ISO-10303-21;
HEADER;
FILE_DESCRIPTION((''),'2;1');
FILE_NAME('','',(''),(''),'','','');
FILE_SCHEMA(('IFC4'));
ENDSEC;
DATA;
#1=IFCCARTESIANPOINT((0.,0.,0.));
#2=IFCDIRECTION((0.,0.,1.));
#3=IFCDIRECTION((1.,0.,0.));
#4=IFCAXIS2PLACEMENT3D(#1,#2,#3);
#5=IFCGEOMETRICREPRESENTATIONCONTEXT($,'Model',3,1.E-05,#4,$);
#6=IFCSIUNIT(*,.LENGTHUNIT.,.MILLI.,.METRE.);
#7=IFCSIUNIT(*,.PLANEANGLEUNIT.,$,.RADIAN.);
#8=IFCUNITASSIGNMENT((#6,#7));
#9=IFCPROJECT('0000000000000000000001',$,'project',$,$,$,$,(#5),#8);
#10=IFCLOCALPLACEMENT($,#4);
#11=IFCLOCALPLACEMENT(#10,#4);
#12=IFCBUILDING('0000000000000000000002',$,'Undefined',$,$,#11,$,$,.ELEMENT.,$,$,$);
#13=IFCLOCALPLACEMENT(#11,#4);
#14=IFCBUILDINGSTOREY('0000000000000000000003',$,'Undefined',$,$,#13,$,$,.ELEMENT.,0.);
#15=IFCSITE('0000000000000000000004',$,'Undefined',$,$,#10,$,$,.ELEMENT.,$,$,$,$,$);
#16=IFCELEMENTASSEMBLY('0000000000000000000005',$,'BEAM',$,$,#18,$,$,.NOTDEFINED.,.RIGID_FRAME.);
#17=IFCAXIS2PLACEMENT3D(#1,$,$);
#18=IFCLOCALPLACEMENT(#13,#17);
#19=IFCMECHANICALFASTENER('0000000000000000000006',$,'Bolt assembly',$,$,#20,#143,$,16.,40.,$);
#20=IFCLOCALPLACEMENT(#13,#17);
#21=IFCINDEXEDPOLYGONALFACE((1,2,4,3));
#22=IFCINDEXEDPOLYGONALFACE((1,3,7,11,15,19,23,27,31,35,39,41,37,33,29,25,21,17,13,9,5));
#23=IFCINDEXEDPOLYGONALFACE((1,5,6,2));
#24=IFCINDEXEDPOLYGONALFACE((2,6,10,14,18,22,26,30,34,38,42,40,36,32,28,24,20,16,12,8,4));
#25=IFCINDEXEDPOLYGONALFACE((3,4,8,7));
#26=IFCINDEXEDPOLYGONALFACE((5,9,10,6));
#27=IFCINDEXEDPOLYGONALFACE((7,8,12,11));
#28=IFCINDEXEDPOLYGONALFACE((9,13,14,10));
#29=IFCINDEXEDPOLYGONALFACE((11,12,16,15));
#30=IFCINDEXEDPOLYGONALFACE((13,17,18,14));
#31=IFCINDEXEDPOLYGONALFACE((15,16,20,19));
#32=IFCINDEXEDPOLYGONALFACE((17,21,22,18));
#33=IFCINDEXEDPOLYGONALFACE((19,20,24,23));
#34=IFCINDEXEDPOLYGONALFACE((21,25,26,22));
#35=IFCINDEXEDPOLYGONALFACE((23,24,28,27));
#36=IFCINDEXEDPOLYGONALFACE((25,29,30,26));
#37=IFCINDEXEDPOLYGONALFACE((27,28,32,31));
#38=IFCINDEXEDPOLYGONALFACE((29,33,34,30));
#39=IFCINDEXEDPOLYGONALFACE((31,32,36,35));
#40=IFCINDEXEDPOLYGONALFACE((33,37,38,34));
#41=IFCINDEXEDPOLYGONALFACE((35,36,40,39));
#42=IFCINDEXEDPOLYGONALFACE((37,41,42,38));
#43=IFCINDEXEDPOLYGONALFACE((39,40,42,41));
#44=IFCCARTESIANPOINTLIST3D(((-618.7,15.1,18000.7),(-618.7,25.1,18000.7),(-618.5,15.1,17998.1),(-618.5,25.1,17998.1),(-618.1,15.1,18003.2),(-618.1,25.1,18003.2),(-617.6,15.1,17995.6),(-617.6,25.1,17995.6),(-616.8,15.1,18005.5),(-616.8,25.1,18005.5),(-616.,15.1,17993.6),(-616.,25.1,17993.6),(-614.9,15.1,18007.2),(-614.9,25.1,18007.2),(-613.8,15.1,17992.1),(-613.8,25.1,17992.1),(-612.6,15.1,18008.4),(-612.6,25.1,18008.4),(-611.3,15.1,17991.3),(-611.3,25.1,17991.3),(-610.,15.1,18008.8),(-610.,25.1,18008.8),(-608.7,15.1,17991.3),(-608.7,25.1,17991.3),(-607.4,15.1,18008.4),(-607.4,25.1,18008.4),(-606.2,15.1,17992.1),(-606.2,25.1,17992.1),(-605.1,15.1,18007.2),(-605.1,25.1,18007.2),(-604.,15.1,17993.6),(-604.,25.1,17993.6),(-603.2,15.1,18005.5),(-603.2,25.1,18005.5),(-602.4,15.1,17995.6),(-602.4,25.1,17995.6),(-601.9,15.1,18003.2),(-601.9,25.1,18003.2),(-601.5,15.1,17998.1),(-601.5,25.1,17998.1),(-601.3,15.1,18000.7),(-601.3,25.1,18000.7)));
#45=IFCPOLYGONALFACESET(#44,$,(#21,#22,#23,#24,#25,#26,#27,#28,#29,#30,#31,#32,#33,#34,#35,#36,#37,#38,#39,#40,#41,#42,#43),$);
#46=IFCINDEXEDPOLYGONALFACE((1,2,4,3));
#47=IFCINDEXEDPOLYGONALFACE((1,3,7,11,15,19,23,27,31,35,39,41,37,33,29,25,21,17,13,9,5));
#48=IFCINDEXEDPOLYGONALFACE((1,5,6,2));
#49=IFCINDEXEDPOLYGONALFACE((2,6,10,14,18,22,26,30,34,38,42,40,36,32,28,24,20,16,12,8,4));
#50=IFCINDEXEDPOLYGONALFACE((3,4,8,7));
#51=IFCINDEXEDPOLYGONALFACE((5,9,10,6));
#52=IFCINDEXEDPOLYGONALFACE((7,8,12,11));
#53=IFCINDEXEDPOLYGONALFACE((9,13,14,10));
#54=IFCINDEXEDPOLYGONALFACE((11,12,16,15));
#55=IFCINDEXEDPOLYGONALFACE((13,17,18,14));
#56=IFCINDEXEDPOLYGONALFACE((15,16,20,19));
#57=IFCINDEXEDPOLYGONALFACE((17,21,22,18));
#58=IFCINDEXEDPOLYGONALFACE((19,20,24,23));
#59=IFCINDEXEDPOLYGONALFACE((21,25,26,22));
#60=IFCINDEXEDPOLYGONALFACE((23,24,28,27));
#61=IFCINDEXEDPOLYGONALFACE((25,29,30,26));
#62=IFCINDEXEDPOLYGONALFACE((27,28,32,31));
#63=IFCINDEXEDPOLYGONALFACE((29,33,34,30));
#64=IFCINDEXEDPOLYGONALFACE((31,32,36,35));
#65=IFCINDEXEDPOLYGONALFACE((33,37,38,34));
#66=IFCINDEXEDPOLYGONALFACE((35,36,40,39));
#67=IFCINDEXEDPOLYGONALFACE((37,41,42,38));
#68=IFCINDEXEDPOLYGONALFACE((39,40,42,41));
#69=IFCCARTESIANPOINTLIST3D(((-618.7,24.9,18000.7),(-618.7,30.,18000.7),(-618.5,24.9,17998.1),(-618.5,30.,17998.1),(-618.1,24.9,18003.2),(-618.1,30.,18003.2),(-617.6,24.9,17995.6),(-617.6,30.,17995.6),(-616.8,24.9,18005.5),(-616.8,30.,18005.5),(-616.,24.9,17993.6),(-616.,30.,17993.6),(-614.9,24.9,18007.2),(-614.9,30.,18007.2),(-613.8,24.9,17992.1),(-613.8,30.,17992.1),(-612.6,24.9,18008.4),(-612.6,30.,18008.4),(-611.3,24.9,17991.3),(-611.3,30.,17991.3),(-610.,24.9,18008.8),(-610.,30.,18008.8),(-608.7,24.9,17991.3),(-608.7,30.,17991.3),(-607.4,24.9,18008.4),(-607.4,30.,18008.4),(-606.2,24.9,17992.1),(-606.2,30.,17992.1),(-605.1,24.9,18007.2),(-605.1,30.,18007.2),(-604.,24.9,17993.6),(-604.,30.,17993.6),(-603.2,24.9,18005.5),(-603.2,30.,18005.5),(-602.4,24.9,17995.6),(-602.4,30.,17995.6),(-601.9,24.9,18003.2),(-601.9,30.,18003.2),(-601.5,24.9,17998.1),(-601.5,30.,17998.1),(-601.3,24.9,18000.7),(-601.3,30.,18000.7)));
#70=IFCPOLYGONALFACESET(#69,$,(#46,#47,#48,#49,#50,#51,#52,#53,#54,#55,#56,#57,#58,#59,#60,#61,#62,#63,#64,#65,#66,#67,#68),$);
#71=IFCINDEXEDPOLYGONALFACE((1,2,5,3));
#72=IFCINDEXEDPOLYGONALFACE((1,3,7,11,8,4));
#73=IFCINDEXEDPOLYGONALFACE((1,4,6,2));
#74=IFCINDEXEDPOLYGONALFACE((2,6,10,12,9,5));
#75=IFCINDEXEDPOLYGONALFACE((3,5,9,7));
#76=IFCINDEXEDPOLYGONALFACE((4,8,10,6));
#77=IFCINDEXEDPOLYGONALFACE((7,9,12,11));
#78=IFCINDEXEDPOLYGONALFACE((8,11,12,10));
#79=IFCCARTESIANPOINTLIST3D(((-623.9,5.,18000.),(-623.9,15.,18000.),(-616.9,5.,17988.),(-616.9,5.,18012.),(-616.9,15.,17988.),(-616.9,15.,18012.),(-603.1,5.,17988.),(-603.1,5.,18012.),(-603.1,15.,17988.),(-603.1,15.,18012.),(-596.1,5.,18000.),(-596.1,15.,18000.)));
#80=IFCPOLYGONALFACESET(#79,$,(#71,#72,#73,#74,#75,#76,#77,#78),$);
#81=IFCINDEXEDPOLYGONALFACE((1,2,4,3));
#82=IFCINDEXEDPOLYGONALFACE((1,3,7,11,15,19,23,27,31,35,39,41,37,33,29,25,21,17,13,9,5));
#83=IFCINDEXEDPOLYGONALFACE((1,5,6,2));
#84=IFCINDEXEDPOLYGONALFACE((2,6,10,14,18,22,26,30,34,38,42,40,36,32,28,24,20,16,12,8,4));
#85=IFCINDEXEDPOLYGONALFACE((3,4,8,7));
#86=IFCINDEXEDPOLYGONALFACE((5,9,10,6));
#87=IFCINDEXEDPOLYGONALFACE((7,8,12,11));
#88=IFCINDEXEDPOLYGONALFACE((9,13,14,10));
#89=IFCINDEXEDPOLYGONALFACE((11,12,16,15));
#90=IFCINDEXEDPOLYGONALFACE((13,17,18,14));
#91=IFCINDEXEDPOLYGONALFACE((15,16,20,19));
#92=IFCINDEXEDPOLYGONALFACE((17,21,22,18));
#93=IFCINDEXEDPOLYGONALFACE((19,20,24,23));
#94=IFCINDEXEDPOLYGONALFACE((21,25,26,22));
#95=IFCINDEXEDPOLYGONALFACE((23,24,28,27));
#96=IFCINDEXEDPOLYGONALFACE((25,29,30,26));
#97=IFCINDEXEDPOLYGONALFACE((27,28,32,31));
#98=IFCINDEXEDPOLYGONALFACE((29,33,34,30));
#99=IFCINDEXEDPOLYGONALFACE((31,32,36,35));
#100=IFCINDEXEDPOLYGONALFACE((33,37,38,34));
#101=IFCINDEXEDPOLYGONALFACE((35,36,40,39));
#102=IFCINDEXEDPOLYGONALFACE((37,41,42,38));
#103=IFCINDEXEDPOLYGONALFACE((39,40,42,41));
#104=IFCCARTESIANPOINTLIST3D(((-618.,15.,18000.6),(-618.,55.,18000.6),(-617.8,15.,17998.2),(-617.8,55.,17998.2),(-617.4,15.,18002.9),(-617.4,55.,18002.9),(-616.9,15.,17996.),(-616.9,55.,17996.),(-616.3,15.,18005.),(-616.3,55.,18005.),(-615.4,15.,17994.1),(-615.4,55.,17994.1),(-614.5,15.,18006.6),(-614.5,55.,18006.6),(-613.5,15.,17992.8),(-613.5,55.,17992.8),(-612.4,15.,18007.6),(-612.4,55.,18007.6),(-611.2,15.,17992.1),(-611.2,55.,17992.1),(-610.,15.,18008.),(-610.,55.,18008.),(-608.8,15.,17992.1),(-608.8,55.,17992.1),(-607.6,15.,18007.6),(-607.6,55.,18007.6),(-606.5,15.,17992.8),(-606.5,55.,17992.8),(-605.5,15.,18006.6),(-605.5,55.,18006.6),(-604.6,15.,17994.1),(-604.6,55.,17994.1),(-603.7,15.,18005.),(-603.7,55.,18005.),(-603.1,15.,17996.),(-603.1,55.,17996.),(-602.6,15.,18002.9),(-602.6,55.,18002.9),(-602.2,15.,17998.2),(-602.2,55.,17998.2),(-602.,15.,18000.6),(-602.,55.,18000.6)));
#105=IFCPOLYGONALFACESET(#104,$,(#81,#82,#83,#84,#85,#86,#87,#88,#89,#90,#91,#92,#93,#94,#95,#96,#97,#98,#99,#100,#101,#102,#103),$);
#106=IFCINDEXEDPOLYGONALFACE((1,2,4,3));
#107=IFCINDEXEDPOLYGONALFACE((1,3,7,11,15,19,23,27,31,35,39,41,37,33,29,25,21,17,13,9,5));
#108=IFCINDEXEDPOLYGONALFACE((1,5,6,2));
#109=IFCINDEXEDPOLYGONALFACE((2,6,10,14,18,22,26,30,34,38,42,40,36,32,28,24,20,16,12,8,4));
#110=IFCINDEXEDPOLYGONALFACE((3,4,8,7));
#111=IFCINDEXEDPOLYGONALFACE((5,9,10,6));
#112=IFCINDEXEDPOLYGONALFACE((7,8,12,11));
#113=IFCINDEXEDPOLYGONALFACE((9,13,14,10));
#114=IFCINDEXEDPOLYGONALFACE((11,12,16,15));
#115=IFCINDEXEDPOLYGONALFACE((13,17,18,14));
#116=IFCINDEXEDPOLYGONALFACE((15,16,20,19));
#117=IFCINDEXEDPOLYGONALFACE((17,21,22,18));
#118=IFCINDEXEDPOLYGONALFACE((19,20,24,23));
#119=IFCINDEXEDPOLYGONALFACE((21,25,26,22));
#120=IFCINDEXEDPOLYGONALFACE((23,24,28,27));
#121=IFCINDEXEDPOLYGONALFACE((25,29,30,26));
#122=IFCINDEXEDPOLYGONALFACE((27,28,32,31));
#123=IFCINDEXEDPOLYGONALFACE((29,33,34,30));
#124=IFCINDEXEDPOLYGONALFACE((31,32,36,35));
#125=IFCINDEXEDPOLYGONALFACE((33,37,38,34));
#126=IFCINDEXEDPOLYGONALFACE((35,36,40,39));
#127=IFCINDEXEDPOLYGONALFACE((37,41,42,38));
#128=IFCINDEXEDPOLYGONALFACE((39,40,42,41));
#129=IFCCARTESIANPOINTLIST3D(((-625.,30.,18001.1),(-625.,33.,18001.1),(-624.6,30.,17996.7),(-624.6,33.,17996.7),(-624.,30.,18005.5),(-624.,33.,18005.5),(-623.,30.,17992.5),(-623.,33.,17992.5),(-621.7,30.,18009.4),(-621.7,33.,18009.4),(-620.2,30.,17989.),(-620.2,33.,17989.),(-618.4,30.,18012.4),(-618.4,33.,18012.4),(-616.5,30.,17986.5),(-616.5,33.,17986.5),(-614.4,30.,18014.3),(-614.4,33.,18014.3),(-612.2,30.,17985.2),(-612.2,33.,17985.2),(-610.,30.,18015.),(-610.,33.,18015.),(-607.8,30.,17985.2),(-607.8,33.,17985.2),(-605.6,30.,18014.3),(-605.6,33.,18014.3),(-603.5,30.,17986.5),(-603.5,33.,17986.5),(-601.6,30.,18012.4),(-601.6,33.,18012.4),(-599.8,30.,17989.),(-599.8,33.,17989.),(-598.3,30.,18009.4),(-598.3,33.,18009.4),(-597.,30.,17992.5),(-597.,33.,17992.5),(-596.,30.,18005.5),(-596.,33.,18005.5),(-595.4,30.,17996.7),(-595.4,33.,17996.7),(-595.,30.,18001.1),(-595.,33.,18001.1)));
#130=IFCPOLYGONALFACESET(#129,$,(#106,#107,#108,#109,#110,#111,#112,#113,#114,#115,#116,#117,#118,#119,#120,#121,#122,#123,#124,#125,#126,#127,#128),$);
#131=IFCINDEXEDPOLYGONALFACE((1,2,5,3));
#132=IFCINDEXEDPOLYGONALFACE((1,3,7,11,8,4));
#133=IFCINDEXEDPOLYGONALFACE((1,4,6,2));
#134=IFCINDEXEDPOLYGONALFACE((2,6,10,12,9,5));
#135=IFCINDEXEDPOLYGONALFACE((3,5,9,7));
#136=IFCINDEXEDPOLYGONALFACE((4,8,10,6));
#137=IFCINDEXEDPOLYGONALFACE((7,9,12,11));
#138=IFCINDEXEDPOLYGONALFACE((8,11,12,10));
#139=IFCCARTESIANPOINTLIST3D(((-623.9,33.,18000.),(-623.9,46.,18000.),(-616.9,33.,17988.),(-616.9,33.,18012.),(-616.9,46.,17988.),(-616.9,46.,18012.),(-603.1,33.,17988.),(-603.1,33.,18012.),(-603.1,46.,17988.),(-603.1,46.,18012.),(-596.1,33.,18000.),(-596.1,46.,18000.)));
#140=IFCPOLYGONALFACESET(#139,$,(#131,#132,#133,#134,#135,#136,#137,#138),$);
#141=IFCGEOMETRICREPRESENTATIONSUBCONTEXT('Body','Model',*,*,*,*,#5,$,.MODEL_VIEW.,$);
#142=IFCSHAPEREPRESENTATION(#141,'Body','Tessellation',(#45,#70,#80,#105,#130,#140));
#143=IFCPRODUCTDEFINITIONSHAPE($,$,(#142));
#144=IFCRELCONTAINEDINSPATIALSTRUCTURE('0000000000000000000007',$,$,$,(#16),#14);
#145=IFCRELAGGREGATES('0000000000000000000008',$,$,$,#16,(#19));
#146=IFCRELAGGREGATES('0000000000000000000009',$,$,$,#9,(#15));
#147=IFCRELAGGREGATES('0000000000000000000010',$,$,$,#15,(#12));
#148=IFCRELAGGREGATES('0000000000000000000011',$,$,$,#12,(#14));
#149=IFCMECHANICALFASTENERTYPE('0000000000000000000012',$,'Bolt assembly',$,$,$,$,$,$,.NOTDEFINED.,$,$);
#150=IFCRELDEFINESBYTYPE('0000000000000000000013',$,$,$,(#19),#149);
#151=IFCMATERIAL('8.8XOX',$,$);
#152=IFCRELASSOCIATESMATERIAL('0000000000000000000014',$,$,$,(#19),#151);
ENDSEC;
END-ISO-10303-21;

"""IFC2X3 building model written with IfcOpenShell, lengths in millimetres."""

from ifc_helpers import new_model, si_unit, frame, origin_with_axes, origin_2d_with_axis, place, context, subcontext, project, spatial, polyline, circle, outline, extrude, source, transform, mapped, material, type_object, element, aggregate, save


model = new_model("IFC2X3")

# Units and contexts
model_context = context("Model", 3, precision=1e-05, world=origin_with_axes())
body_context = subcontext(model_context, "Body", "Model", "MODEL_VIEW")
ifc_project = project(units=[si_unit("LENGTHUNIT", "METRE", prefix="MILLI"), si_unit("PLANEANGLEUNIT", "RADIAN")], contexts=[model_context])

# Site, building, storey
site_placement = place(None, origin_with_axes())
site = spatial("IfcSite", under=ifc_project, at=site_placement, Name="Undefined", CompositionType="ELEMENT")
building_placement = place(site_placement, origin_with_axes())
building = spatial("IfcBuilding", under=site, at=building_placement, Name="Undefined", CompositionType="ELEMENT")
storey_placement = place(building_placement, origin_with_axes())
storey = spatial("IfcBuildingStorey", under=building, at=storey_placement, Name="Undefined", CompositionType="ELEMENT", Elevation=0.0)

# Element assembly
assembly_1_placement = place(storey_placement, origin_with_axes())
assembly_1 = element("IfcElementAssembly", 1, at=assembly_1_placement, inside=storey, Name="BEAM", AssemblyPlace="NOTDEFINED", PredefinedType="RIGID_FRAME")

# Mechanical fastener
ifc_material_1 = material(Name="8.8XOX")
mechanical_fastener_type = type_object("IfcMechanicalFastenerType", Name="Bolt assembly")
shared_shape_1 = source(origin_with_axes(), body_context, "Body", "SweptSolid", [
    extrude(circle(Radius=8.8, at=origin_2d_with_axis()), frame((0.0, 15.1, 0.0), z_axis=(0.0, 1.0, 0.0), x_axis=(1.0, 0.0, 0.0)), (0.0, 0.0, 1.0), 10.0),
    extrude(circle(Radius=8.8, at=origin_2d_with_axis()), frame((0.0, 24.9, 0.0), z_axis=(0.0, 1.0, 0.0), x_axis=(1.0, 0.0, 0.0)), (0.0, 0.0, 1.0), 5.1),
    extrude(outline(polyline([(12.0, -6.9), (12.0, 6.9), (0.0, 13.9), (-12.0, 6.9), (-12.0, -6.9), (0.0, -13.9), (12.0, -6.9)])), frame((0.0, 5.0, 0.0), z_axis=(0.0, 1.0, 0.0), x_axis=(1.0, 0.0, 0.0)), (0.0, 0.0, 1.0), 10.0),
    extrude(circle(Radius=8.0, at=origin_2d_with_axis()), frame((0.0, 15.0, 0.0), z_axis=(0.0, 1.0, 0.0), x_axis=(1.0, 0.0, 0.0)), (0.0, 0.0, 1.0), 40.0),
    extrude(circle(Radius=15.0, at=origin_2d_with_axis()), frame((0.0, 30.0, 0.0), z_axis=(0.0, 1.0, 0.0), x_axis=(1.0, 0.0, 0.0)), (0.0, 0.0, 1.0), 3.0),
    extrude(outline(polyline([(12.0, -6.9), (12.0, 6.9), (0.0, 13.9), (-12.0, 6.9), (-12.0, -6.9), (0.0, -13.9), (12.0, -6.9)])), frame((0.0, 33.0, 0.0), z_axis=(0.0, 1.0, 0.0), x_axis=(1.0, 0.0, 0.0)), (0.0, 0.0, 1.0), 13.0),
])
mechanical_fastener_1_placement = place(assembly_1_placement, frame((-610.0, 0.0, 18000.0), z_axis=(-1.0, 0.0, 0.0), x_axis=(0.0, 0.0, 1.0)))
mechanical_fastener_1 = element("IfcMechanicalFastener", 2, at=mechanical_fastener_1_placement, type_object=mechanical_fastener_type, material=ifc_material_1, Name="Bolt assembly", NominalDiameter=16.0, NominalLength=40.0, context=body_context, shape_type="MappedRepresentation", body=[
    mapped(shared_shape_1, transform((0.0, 0.0, 0.0))),
])
aggregate(assembly_1, [mechanical_fastener_1])

save(model, "model.ifc")
